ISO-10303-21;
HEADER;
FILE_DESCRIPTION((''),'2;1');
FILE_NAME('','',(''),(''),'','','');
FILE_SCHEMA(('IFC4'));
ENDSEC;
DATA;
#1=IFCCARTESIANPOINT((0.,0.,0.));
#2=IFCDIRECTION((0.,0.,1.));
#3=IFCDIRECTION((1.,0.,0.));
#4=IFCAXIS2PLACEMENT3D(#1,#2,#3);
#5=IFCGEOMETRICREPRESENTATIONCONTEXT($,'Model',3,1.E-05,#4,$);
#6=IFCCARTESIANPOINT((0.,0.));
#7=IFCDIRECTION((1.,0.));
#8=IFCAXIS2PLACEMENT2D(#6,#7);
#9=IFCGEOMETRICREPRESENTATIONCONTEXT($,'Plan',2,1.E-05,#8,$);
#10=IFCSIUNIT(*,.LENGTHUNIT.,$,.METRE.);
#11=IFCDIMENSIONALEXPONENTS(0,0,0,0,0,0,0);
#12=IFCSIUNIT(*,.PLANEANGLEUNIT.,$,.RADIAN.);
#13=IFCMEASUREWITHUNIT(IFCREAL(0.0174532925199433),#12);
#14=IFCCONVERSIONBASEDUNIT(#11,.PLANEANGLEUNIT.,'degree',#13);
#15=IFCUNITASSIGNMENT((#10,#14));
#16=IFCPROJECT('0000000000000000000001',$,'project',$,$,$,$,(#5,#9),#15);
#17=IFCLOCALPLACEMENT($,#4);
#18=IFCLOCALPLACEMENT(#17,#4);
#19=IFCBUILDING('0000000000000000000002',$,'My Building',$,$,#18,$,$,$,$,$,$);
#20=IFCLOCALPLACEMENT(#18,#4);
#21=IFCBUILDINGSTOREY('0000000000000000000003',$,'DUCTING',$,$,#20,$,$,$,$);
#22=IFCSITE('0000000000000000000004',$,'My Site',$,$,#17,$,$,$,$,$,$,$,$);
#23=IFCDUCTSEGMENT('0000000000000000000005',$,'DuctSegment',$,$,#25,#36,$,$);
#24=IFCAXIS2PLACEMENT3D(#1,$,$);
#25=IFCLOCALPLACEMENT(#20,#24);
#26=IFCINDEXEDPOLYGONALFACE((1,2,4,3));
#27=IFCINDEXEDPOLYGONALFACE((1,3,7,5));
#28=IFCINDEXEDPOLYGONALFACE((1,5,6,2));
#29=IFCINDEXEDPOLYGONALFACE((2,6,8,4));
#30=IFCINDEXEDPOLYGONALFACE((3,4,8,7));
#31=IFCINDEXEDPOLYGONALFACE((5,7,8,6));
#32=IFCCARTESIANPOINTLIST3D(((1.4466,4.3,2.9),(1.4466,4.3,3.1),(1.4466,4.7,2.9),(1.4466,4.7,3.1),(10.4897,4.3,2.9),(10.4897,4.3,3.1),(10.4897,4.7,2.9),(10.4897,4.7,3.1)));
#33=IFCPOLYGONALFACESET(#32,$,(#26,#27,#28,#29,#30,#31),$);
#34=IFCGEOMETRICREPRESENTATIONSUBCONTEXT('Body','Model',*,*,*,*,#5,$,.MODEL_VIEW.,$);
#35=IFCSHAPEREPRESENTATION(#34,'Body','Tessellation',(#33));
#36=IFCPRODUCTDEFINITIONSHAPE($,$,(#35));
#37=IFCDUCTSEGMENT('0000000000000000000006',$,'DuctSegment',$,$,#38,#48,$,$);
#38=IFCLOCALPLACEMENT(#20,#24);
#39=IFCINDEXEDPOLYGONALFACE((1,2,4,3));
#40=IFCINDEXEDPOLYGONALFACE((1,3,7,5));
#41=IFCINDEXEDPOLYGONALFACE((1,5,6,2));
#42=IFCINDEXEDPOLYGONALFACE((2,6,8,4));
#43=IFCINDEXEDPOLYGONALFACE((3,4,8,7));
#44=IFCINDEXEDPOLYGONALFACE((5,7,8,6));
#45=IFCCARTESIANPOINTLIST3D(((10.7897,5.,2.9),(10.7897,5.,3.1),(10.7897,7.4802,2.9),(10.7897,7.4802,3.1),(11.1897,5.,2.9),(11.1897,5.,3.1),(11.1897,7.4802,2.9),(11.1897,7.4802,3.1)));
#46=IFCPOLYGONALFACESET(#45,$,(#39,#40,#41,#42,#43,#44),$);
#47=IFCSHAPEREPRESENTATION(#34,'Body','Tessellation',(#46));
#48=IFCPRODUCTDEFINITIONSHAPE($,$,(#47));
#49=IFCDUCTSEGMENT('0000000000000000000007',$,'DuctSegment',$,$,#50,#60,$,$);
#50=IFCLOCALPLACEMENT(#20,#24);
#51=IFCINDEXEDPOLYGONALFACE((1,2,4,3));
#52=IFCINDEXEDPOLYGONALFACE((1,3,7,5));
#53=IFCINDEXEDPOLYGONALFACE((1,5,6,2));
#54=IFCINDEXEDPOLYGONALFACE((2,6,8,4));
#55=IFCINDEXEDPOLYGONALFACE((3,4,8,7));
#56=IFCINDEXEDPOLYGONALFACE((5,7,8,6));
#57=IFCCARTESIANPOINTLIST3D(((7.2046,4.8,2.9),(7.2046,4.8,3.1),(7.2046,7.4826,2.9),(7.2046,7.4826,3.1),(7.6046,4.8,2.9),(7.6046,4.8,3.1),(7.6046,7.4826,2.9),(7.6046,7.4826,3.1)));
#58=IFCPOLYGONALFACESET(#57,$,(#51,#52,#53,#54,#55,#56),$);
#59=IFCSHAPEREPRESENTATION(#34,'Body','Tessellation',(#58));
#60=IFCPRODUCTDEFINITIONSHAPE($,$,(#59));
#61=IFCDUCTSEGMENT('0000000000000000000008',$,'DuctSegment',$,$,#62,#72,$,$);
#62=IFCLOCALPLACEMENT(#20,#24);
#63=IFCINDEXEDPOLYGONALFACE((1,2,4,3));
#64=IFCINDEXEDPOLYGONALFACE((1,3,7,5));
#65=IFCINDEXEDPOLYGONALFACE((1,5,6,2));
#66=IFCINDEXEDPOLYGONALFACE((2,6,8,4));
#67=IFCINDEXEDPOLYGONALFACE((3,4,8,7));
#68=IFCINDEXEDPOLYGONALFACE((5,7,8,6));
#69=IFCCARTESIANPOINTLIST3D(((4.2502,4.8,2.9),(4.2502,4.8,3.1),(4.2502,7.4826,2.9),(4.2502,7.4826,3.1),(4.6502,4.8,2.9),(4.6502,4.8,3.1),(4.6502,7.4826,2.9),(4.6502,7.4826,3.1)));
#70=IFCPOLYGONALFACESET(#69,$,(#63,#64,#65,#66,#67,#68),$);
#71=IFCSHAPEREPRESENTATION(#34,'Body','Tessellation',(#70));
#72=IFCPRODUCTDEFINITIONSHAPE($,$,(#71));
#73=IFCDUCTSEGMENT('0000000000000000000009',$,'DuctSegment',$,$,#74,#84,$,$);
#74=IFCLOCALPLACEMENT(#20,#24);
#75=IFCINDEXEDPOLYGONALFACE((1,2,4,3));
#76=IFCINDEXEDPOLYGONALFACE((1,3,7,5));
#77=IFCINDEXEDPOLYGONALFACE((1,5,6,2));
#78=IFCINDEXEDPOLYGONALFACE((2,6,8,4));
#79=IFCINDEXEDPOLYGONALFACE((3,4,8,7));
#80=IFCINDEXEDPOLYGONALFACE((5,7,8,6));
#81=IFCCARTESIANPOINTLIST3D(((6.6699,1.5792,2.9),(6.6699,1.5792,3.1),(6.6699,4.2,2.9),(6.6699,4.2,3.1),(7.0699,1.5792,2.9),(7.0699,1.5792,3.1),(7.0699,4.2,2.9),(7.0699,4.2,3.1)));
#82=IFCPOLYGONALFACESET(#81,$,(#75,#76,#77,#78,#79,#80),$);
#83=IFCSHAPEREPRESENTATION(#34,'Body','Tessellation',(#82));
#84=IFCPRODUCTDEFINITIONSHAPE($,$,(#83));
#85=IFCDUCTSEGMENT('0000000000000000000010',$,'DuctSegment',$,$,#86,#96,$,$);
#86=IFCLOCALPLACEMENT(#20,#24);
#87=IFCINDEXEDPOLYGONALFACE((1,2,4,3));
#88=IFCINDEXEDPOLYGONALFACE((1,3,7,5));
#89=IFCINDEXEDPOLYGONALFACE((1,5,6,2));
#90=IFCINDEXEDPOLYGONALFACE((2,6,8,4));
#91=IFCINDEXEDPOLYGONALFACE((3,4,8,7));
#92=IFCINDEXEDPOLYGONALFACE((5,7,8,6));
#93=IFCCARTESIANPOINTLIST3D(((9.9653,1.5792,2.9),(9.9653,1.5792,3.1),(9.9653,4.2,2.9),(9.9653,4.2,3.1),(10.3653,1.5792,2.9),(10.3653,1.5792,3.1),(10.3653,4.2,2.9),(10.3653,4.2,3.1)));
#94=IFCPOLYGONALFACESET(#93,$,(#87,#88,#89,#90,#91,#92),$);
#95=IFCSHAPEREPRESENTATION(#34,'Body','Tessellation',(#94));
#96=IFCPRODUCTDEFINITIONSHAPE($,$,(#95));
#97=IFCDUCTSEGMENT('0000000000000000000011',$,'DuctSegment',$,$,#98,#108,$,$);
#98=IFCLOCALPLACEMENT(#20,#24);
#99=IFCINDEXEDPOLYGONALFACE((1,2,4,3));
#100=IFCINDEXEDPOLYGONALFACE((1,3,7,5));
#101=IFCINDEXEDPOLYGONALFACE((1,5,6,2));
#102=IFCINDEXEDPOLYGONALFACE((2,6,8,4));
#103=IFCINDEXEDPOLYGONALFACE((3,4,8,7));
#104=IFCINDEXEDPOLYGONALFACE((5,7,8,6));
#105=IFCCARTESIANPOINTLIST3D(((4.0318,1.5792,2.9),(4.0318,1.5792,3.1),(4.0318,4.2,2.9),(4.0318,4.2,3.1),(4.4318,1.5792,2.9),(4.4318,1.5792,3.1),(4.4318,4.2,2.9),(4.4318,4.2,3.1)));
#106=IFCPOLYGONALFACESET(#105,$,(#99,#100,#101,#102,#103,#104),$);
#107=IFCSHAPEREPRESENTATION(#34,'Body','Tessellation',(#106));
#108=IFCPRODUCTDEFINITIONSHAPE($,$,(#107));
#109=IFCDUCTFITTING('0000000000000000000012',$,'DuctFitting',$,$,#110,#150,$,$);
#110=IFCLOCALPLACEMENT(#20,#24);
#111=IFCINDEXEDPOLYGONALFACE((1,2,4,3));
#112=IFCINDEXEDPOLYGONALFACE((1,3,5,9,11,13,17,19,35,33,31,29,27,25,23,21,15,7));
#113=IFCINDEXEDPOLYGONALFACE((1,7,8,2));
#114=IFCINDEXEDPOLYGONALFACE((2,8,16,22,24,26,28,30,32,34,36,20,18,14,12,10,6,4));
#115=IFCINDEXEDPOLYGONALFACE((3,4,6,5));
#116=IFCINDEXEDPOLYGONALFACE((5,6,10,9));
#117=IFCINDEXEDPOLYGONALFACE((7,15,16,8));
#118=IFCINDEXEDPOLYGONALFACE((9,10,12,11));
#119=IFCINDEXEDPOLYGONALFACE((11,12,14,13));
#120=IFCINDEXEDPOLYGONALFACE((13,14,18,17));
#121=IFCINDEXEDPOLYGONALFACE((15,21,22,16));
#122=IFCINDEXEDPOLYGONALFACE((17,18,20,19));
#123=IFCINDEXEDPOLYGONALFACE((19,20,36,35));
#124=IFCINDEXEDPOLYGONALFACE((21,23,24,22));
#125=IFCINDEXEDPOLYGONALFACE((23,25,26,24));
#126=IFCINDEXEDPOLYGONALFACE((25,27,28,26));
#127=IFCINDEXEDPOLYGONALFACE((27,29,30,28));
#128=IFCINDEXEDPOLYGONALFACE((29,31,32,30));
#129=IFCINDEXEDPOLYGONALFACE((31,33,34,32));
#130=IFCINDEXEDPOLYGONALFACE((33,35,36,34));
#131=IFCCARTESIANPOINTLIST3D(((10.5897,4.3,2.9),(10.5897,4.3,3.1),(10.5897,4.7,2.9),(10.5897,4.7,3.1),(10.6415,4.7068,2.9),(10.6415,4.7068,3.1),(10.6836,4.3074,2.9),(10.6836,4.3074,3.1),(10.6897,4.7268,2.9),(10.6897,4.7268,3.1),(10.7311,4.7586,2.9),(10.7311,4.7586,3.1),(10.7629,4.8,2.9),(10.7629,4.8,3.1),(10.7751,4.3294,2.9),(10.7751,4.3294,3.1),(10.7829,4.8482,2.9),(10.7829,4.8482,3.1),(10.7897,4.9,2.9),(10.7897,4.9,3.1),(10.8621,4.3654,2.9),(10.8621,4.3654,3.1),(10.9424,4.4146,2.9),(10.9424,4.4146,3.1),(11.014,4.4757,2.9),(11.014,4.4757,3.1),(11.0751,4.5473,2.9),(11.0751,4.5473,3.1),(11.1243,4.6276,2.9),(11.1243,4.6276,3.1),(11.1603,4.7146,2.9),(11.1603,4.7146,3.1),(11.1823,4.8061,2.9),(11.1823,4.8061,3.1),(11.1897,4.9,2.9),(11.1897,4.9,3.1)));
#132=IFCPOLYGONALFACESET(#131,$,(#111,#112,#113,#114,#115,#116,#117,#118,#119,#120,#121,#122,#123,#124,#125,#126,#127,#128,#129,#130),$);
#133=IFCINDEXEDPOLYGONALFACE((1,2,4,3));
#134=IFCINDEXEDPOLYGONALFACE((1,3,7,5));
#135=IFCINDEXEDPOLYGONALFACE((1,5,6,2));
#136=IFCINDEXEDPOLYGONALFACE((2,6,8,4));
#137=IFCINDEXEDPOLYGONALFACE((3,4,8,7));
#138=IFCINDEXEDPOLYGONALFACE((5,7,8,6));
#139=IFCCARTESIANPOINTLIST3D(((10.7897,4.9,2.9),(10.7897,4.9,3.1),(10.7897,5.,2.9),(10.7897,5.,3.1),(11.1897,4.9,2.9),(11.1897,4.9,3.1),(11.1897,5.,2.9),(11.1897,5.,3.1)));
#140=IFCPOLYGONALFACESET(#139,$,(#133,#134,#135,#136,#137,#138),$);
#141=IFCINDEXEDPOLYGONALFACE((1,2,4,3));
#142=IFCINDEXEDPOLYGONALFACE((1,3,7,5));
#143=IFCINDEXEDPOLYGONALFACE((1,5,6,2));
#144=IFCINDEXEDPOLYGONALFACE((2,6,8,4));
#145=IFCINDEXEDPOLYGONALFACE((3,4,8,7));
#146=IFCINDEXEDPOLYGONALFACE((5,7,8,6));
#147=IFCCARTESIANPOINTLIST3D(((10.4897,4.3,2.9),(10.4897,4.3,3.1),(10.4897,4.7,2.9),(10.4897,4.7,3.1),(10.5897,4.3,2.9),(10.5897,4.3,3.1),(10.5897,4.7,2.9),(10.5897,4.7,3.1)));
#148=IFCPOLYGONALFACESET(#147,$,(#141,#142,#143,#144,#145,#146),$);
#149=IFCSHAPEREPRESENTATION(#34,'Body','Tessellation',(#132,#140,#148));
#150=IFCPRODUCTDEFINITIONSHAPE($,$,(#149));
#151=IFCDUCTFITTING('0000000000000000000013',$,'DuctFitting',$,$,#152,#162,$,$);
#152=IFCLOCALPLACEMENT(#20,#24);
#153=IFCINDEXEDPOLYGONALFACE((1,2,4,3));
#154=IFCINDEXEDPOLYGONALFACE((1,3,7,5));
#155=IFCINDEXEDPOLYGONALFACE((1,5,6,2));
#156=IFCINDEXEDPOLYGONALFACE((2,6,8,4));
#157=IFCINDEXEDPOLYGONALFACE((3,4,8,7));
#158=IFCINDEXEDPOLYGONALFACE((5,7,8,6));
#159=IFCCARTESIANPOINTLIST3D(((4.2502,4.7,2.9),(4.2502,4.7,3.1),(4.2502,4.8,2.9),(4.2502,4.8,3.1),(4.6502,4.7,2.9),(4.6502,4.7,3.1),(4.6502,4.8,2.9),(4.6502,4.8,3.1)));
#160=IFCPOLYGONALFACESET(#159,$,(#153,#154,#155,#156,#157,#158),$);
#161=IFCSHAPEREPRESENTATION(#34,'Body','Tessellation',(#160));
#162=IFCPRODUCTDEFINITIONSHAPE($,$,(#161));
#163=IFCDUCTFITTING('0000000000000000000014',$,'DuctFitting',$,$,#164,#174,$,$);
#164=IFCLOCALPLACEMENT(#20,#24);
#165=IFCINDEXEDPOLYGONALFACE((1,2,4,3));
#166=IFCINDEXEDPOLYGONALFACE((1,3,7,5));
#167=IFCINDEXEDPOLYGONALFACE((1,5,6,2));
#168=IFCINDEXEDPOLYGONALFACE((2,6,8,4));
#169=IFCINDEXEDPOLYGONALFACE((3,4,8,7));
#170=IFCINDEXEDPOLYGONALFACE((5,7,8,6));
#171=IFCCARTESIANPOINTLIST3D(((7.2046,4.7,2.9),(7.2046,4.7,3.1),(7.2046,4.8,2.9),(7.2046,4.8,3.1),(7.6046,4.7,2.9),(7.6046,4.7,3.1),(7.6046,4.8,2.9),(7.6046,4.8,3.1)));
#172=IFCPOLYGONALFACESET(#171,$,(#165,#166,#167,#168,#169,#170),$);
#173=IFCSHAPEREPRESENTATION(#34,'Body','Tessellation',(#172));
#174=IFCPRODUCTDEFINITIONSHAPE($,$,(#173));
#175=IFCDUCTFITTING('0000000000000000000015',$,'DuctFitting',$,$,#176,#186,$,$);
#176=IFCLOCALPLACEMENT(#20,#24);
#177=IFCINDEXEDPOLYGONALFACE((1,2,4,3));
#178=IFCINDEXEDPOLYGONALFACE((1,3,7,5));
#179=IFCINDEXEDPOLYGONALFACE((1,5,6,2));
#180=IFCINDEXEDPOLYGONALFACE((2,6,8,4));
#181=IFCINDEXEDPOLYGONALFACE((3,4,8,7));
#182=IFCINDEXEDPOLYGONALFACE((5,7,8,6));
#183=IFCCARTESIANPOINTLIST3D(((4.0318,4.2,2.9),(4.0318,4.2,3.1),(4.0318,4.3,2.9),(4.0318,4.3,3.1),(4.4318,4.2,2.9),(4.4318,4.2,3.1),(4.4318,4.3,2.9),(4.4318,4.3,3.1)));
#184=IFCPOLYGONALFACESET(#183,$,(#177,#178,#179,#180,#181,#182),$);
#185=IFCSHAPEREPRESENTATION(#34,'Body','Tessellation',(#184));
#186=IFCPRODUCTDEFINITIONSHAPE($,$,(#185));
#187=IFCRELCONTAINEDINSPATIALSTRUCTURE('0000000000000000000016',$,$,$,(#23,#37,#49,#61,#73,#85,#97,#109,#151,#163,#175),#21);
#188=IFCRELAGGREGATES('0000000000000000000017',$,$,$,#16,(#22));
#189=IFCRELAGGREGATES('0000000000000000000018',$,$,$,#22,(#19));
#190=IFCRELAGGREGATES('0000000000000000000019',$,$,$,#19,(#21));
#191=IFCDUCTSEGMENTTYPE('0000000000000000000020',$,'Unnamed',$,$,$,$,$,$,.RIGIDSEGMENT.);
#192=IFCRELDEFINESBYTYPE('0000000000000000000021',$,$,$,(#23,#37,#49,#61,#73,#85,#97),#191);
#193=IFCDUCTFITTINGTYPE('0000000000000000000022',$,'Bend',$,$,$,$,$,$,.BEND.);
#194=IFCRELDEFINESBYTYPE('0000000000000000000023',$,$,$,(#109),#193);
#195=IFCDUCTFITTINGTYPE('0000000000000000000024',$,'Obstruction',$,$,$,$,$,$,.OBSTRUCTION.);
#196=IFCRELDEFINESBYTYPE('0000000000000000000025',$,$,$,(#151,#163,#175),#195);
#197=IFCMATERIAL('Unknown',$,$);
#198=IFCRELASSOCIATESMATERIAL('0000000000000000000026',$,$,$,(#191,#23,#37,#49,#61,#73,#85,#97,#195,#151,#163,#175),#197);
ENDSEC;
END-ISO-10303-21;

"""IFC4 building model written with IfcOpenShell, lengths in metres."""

from ifc_helpers import new_model, entity, si_unit, converted_unit, frame, origin_with_axes, origin_2d_with_axis, place, context, subcontext, project, spatial, line, arc, indexed_curve, rectangle, outline, extrude, source, transform, mapped, material, material_profile, profile_set, profile_usage, type_object, type_shapes, element, save


model = new_model("IFC4")

# Units and contexts
model_context = context("Model", 3, precision=1e-05, world=origin_with_axes())
plan_context = context("Plan", 2, precision=1e-05, world=origin_2d_with_axis())
body_context = subcontext(model_context, "Body", "Model", "MODEL_VIEW")
ifc_project = project(units=[si_unit("LENGTHUNIT", "METRE"), converted_unit("PLANEANGLEUNIT", "degree", entity("IfcReal", 0.0174532925199433), si_unit("PLANEANGLEUNIT", "RADIAN"), dimensions=[0, 0, 0, 0, 0, 0, 0])], contexts=[model_context, plan_context])

# Site, building, storey
site_placement = place(None, origin_with_axes())
site = spatial("IfcSite", under=ifc_project, at=site_placement, Name="My Site")
building_placement = place(site_placement, origin_with_axes())
building = spatial("IfcBuilding", under=site, at=building_placement, Name="My Building")
storey_placement = place(building_placement, origin_with_axes())
storey = spatial("IfcBuildingStorey", under=building, at=storey_placement, Name="DUCTING")

# Duct segments
ifc_material = material(Name="Unknown")
ifc_material_profile_1 = material_profile(ifc_material, rectangle(XDim=0.4, YDim=0.2))
ifc_profile_set_1 = profile_set([ifc_material_profile_1])
ifc_profile_usage_1 = profile_usage(ifc_profile_set_1, cardinal=5)
duct_segment_type = type_object("IfcDuctSegmentType", Name="Unnamed", PredefinedType="RIGIDSEGMENT", material=ifc_profile_set_1)
duct_segment_1_placement = place(storey_placement, frame((1.4466, 4.5, 3.0), z_axis=(1.0, 0.0, 0.0), x_axis=(0.0, 1.0, 0.0)))
element("IfcDuctSegment", 1, at=duct_segment_1_placement, inside=storey, type_object=duct_segment_type, material=ifc_profile_usage_1, Name="DuctSegment", context=body_context, shape_type="SweptSolid", body=[
    extrude(rectangle(XDim=0.4, YDim=0.2), origin_with_axes(), (0.0, 0.0, 1.0), 9.0432),
])
ifc_profile_usage_2 = profile_usage(ifc_profile_set_1, cardinal=5)
duct_segment_2_placement = place(storey_placement, frame((10.9897, 5.0, 3.0), z_axis=(0.0, 1.0, 0.0), x_axis=(-1.0, 0.0, 0.0)))
element("IfcDuctSegment", 2, at=duct_segment_2_placement, inside=storey, type_object=duct_segment_type, material=ifc_profile_usage_2, Name="DuctSegment", context=body_context, shape_type="SweptSolid", body=[
    extrude(rectangle(XDim=0.4, YDim=0.2), origin_with_axes(), (0.0, 0.0, 1.0), 2.4802),
])
ifc_profile_usage_3 = profile_usage(ifc_profile_set_1, cardinal=5)
duct_segment_3_placement = place(storey_placement, frame((7.4046, 4.8, 3.0), z_axis=(0.0, 1.0, 0.0), x_axis=(-1.0, 0.0, 0.0)))
element("IfcDuctSegment", 3, at=duct_segment_3_placement, inside=storey, type_object=duct_segment_type, material=ifc_profile_usage_3, Name="DuctSegment", context=body_context, shape_type="SweptSolid", body=[
    extrude(rectangle(XDim=0.4, YDim=0.2), origin_with_axes(), (0.0, 0.0, 1.0), 2.6826),
])
ifc_profile_usage_4 = profile_usage(ifc_profile_set_1, cardinal=5)
duct_segment_4_placement = place(storey_placement, frame((4.4502, 4.8, 3.0), z_axis=(0.0, 1.0, 0.0), x_axis=(-1.0, 0.0, 0.0)))
element("IfcDuctSegment", 4, at=duct_segment_4_placement, inside=storey, type_object=duct_segment_type, material=ifc_profile_usage_4, Name="DuctSegment", context=body_context, shape_type="SweptSolid", body=[
    extrude(rectangle(XDim=0.4, YDim=0.2), origin_with_axes(), (0.0, 0.0, 1.0), 2.6826),
])
ifc_profile_usage_5 = profile_usage(ifc_profile_set_1, cardinal=5)
duct_segment_5_placement = place(storey_placement, frame((6.8699, 4.2, 3.0), z_axis=(0.0, -1.0, 0.0), x_axis=(1.0, 0.0, 0.0)))
element("IfcDuctSegment", 5, at=duct_segment_5_placement, inside=storey, type_object=duct_segment_type, material=ifc_profile_usage_5, Name="DuctSegment", context=body_context, shape_type="SweptSolid", body=[
    extrude(rectangle(XDim=0.4, YDim=0.2), origin_with_axes(), (0.0, 0.0, 1.0), 2.6208),
])
ifc_profile_usage_6 = profile_usage(ifc_profile_set_1, cardinal=5)
duct_segment_6_placement = place(storey_placement, frame((10.1653, 4.2, 3.0), z_axis=(0.0, -1.0, 0.0), x_axis=(1.0, 0.0, 0.0)))
element("IfcDuctSegment", 6, at=duct_segment_6_placement, inside=storey, type_object=duct_segment_type, material=ifc_profile_usage_6, Name="DuctSegment", context=body_context, shape_type="SweptSolid", body=[
    extrude(rectangle(XDim=0.4, YDim=0.2), origin_with_axes(), (0.0, 0.0, 1.0), 2.6208),
])
ifc_profile_usage_7 = profile_usage(ifc_profile_set_1, cardinal=5)
duct_segment_7_placement = place(storey_placement, frame((4.2318, 4.2, 3.0), z_axis=(0.0, -1.0, 0.0), x_axis=(1.0, 0.0, 0.0)))
element("IfcDuctSegment", 7, at=duct_segment_7_placement, inside=storey, type_object=duct_segment_type, material=ifc_profile_usage_7, Name="DuctSegment", context=body_context, shape_type="SweptSolid", body=[
    extrude(rectangle(XDim=0.4, YDim=0.2), origin_with_axes(), (0.0, 0.0, 1.0), 2.6208),
])

# Duct fittings
duct_fitting_type_1 = type_object("IfcDuctFittingType", Name="Bend", PredefinedType="BEND")
shared_shape = source(origin_with_axes(), body_context, "Body", "SweptSolid", [
    extrude(outline(indexed_curve([(0.2, 0.0), (0.2586, -0.1414), (0.4, -0.2), (0.4, -0.6), (-0.0243, -0.4243), (-0.2, 0.0)], segments=[arc(1, 2, 3), line(3, 4), arc(4, 5, 6), line(6, 1)])), frame((0.0, -0.1, -0.1), z_axis=(0.0, -1.0, 0.0), x_axis=(1.0, 0.0, 0.0)), (0.0, 0.0, -1.0), 0.2),
    extrude(rectangle(XDim=0.4, YDim=0.2), origin_with_axes(), (0.0, 0.0, -1.0), 0.1),
    extrude(rectangle(XDim=0.4, YDim=0.2), frame((0.4, 0.0, -0.5), z_axis=(1.0, 0.0, 0.0), x_axis=(0.0, 0.0, 1.0)), (0.0, 0.0, 1.0), 0.1),
])
type_shapes(duct_fitting_type_1, [shared_shape])
duct_fitting_1_placement = place(storey_placement, frame((10.9897, 5.0, 3.0), z_axis=(0.0, 1.0, 0.0), x_axis=(-1.0, 0.0, 0.0)))
element("IfcDuctFitting", 8, at=duct_fitting_1_placement, inside=storey, type_object=duct_fitting_type_1, Name="DuctFitting", context=body_context, shape_type="MappedRepresentation", body=[
    mapped(shared_shape, transform((0.0, 0.0, 0.0), x_axis=(1.0, 0.0, 0.0), y_axis=(0.0, 1.0, 0.0), z_axis=(0.0, 0.0, 1.0), scale=1.0)),
])
ifc_material_profile_2 = material_profile(ifc_material, rectangle(XDim=0.4, YDim=0.2))
ifc_profile_set_2 = profile_set([ifc_material_profile_2])
ifc_profile_usage_8 = profile_usage(ifc_profile_set_2, cardinal=5)
duct_fitting_type_2 = type_object("IfcDuctFittingType", Name="Obstruction", PredefinedType="OBSTRUCTION", material=ifc_profile_set_2)
duct_fitting_2_placement = place(storey_placement, frame((4.4502, 4.7, 3.0), z_axis=(0.0, 1.0, 0.0), x_axis=(-1.0, 0.0, 0.0)))
element("IfcDuctFitting", 9, at=duct_fitting_2_placement, inside=storey, type_object=duct_fitting_type_2, material=ifc_profile_usage_8, Name="DuctFitting", context=body_context, shape_type="SweptSolid", body=[
    extrude(rectangle(XDim=0.4, YDim=0.2), origin_with_axes(), (0.0, 0.0, 1.0), 0.1),
])
ifc_profile_usage_9 = profile_usage(ifc_profile_set_2, cardinal=5)
duct_fitting_3_placement = place(storey_placement, frame((7.4046, 4.7, 3.0), z_axis=(0.0, 1.0, 0.0), x_axis=(-1.0, 0.0, 0.0)))
element("IfcDuctFitting", 10, at=duct_fitting_3_placement, inside=storey, type_object=duct_fitting_type_2, material=ifc_profile_usage_9, Name="DuctFitting", context=body_context, shape_type="SweptSolid", body=[
    extrude(rectangle(XDim=0.4, YDim=0.2), origin_with_axes(), (0.0, 0.0, 1.0), 0.1),
])
ifc_profile_usage_10 = profile_usage(ifc_profile_set_2, cardinal=5)
duct_fitting_4_placement = place(storey_placement, frame((4.2318, 4.3, 3.0), z_axis=(0.0, -1.0, 0.0), x_axis=(1.0, 0.0, 0.0)))
element("IfcDuctFitting", 11, at=duct_fitting_4_placement, inside=storey, type_object=duct_fitting_type_2, material=ifc_profile_usage_10, Name="DuctFitting", context=body_context, shape_type="SweptSolid", body=[
    extrude(rectangle(XDim=0.4, YDim=0.2), origin_with_axes(), (0.0, 0.0, 1.0), 0.1),
])

save(model, "model.ifc")
